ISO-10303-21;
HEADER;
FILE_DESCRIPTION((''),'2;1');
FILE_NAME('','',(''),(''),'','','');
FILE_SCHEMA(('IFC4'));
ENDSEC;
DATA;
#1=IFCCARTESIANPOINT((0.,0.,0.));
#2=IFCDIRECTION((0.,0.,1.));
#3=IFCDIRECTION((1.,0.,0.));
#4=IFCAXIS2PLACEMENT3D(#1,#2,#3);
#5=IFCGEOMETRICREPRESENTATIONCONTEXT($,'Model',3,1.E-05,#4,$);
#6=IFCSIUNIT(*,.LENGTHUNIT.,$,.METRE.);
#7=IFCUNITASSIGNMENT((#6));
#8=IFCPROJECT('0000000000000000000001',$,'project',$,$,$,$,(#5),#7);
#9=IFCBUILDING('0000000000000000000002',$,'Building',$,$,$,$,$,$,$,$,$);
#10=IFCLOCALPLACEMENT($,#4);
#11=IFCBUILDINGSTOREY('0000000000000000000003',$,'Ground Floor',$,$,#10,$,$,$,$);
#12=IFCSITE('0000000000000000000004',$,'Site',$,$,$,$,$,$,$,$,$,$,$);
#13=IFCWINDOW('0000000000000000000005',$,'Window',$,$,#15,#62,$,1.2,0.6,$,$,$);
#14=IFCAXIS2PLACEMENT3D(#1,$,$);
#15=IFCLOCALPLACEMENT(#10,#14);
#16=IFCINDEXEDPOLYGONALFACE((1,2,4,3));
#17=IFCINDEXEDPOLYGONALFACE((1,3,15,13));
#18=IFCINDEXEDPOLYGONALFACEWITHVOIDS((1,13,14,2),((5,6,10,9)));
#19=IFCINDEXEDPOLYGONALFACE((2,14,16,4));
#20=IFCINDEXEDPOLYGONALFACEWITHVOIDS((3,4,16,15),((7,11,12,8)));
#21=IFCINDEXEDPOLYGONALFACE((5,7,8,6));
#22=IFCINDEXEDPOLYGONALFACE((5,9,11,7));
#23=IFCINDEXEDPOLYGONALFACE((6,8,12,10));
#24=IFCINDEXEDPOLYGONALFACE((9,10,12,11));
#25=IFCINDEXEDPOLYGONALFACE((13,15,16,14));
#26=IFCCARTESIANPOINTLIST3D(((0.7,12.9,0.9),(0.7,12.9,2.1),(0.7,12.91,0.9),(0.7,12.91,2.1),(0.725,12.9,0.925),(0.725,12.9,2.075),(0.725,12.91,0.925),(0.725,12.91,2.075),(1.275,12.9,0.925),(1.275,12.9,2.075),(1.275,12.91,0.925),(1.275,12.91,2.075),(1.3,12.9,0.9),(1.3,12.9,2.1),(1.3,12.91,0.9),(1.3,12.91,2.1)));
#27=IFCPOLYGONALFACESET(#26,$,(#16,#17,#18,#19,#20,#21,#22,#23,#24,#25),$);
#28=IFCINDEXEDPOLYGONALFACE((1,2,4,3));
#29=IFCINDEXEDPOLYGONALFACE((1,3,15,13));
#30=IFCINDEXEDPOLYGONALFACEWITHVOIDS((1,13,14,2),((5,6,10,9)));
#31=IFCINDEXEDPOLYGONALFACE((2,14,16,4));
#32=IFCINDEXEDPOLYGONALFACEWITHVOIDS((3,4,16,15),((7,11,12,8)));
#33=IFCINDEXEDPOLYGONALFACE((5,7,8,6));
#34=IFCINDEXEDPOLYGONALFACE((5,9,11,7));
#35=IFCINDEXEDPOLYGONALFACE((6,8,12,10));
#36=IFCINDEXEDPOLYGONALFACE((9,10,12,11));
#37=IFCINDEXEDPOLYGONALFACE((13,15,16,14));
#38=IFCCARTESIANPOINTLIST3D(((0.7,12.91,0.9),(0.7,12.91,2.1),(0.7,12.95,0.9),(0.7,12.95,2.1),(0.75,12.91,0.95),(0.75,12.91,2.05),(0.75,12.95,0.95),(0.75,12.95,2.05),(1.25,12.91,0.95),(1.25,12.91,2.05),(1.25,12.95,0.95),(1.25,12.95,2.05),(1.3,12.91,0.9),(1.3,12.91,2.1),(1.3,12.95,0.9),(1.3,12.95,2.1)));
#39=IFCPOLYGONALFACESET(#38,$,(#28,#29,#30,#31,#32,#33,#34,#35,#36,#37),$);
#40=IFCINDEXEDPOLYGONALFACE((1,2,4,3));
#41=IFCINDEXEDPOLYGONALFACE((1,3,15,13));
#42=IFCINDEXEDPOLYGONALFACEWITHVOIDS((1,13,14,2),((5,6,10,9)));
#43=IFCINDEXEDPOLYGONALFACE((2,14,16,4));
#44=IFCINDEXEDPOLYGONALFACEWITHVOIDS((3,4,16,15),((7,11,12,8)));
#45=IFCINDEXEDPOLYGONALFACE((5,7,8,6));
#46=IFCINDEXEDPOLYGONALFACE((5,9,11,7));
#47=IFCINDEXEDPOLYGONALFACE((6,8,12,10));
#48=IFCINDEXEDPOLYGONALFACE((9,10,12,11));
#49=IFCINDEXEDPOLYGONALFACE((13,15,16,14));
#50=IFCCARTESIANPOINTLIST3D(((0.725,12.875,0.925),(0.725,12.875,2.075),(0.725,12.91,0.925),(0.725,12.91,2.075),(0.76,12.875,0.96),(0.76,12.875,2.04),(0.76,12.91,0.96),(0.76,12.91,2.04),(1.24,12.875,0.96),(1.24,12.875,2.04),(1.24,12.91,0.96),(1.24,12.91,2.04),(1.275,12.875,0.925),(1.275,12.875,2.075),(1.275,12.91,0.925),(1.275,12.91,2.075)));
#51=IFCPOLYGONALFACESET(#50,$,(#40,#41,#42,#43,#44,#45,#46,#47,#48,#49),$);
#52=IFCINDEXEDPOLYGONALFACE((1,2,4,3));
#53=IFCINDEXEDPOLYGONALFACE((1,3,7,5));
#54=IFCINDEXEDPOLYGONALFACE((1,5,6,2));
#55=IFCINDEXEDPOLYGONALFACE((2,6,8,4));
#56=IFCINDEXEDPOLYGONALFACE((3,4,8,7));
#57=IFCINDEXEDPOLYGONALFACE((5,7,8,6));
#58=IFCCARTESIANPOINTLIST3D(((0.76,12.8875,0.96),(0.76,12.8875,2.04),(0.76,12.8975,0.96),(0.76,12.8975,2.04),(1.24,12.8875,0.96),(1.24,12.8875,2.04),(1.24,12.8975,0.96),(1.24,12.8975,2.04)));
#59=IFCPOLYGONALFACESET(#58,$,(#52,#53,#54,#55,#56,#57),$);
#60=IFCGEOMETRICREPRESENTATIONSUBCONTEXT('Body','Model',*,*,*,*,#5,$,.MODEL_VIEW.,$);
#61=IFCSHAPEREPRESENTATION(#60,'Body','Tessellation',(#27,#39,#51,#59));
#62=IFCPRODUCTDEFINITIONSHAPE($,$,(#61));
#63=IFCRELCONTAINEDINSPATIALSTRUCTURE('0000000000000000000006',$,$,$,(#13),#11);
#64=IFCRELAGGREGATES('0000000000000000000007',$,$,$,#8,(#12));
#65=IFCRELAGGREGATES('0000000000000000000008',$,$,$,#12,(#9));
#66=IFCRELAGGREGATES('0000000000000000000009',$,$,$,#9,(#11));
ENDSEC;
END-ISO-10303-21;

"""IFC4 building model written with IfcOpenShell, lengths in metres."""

from ifc_helpers import new_model, si_unit, frame, origin_with_axes, place, context, subcontext, project, spatial, line, indexed_curve, outline, extrude, element, save


model = new_model("IFC4")

# Units and contexts
model_context = context("Model", 3, precision=1e-05, world=origin_with_axes())
body_context = subcontext(model_context, "Body", "Model", "MODEL_VIEW")
ifc_project = project(units=[si_unit("LENGTHUNIT", "METRE")], contexts=[model_context])

# Site, building, storey
site = spatial("IfcSite", under=ifc_project, Name="Site")
building = spatial("IfcBuilding", under=site, Name="Building")
storey_placement = place(None, origin_with_axes())
storey = spatial("IfcBuildingStorey", under=building, at=storey_placement, Name="Ground Floor")

# Window
window_1_placement = place(storey_placement, frame((1.3, 13.0, 0.9), z_axis=(0.0, 0.0, 1.0), x_axis=(-1.0, 0.0, 0.0)))
element("IfcWindow", 1, at=window_1_placement, inside=storey, Name="Window", OverallHeight=1.2, OverallWidth=0.6, context=body_context, shape_type="SweptSolid", body=[
    extrude(outline(indexed_curve([(0.0, 0.0), (0.6, 0.0), (0.6, 1.2), (0.0, 1.2)], segments=[line(1, 2, 3, 4, 1)]), holes=[indexed_curve([(0.025, 0.025), (0.575, 0.025), (0.575, 1.175), (0.025, 1.175)], segments=[line(1, 2, 3, 4, 1)])]), frame((0.0, 0.09, 0.0), z_axis=(0.0, -1.0, 0.0), x_axis=(1.0, 0.0, 0.0)), (0.0, 0.0, -1.0), 0.01),
    extrude(outline(indexed_curve([(0.0, 0.0), (0.6, 0.0), (0.6, 1.2), (0.0, 1.2)], segments=[line(1, 2, 3, 4, 1)]), holes=[indexed_curve([(0.05, 0.05), (0.55, 0.05), (0.55, 1.15), (0.05, 1.15)], segments=[line(1, 2, 3, 4, 1)])]), frame((0.0, 0.05, 0.0), z_axis=(0.0, -1.0, 0.0), x_axis=(1.0, 0.0, 0.0)), (0.0, 0.0, -1.0), 0.04),
    extrude(outline(indexed_curve([(0.0, 0.0), (0.55, 0.0), (0.55, 1.15), (0.0, 1.15)], segments=[line(1, 2, 3, 4, 1)]), holes=[indexed_curve([(0.035, 0.035), (0.515, 0.035), (0.515, 1.115), (0.035, 1.115)], segments=[line(1, 2, 3, 4, 1)])]), frame((0.025, 0.09, 0.025), z_axis=(0.0, -1.0, 0.0), x_axis=(1.0, 0.0, 0.0)), (0.0, 0.0, -1.0), 0.035),
    extrude(outline(indexed_curve([(0.035, 0.035), (0.515, 0.035), (0.515, 1.115), (0.035, 1.115)], segments=[line(1, 2, 3, 4, 1)])), frame((0.025, 0.1025, 0.025), z_axis=(0.0, -1.0, 0.0), x_axis=(1.0, 0.0, 0.0)), (0.0, 0.0, -1.0), 0.01),
])

save(model, "model.ifc")
